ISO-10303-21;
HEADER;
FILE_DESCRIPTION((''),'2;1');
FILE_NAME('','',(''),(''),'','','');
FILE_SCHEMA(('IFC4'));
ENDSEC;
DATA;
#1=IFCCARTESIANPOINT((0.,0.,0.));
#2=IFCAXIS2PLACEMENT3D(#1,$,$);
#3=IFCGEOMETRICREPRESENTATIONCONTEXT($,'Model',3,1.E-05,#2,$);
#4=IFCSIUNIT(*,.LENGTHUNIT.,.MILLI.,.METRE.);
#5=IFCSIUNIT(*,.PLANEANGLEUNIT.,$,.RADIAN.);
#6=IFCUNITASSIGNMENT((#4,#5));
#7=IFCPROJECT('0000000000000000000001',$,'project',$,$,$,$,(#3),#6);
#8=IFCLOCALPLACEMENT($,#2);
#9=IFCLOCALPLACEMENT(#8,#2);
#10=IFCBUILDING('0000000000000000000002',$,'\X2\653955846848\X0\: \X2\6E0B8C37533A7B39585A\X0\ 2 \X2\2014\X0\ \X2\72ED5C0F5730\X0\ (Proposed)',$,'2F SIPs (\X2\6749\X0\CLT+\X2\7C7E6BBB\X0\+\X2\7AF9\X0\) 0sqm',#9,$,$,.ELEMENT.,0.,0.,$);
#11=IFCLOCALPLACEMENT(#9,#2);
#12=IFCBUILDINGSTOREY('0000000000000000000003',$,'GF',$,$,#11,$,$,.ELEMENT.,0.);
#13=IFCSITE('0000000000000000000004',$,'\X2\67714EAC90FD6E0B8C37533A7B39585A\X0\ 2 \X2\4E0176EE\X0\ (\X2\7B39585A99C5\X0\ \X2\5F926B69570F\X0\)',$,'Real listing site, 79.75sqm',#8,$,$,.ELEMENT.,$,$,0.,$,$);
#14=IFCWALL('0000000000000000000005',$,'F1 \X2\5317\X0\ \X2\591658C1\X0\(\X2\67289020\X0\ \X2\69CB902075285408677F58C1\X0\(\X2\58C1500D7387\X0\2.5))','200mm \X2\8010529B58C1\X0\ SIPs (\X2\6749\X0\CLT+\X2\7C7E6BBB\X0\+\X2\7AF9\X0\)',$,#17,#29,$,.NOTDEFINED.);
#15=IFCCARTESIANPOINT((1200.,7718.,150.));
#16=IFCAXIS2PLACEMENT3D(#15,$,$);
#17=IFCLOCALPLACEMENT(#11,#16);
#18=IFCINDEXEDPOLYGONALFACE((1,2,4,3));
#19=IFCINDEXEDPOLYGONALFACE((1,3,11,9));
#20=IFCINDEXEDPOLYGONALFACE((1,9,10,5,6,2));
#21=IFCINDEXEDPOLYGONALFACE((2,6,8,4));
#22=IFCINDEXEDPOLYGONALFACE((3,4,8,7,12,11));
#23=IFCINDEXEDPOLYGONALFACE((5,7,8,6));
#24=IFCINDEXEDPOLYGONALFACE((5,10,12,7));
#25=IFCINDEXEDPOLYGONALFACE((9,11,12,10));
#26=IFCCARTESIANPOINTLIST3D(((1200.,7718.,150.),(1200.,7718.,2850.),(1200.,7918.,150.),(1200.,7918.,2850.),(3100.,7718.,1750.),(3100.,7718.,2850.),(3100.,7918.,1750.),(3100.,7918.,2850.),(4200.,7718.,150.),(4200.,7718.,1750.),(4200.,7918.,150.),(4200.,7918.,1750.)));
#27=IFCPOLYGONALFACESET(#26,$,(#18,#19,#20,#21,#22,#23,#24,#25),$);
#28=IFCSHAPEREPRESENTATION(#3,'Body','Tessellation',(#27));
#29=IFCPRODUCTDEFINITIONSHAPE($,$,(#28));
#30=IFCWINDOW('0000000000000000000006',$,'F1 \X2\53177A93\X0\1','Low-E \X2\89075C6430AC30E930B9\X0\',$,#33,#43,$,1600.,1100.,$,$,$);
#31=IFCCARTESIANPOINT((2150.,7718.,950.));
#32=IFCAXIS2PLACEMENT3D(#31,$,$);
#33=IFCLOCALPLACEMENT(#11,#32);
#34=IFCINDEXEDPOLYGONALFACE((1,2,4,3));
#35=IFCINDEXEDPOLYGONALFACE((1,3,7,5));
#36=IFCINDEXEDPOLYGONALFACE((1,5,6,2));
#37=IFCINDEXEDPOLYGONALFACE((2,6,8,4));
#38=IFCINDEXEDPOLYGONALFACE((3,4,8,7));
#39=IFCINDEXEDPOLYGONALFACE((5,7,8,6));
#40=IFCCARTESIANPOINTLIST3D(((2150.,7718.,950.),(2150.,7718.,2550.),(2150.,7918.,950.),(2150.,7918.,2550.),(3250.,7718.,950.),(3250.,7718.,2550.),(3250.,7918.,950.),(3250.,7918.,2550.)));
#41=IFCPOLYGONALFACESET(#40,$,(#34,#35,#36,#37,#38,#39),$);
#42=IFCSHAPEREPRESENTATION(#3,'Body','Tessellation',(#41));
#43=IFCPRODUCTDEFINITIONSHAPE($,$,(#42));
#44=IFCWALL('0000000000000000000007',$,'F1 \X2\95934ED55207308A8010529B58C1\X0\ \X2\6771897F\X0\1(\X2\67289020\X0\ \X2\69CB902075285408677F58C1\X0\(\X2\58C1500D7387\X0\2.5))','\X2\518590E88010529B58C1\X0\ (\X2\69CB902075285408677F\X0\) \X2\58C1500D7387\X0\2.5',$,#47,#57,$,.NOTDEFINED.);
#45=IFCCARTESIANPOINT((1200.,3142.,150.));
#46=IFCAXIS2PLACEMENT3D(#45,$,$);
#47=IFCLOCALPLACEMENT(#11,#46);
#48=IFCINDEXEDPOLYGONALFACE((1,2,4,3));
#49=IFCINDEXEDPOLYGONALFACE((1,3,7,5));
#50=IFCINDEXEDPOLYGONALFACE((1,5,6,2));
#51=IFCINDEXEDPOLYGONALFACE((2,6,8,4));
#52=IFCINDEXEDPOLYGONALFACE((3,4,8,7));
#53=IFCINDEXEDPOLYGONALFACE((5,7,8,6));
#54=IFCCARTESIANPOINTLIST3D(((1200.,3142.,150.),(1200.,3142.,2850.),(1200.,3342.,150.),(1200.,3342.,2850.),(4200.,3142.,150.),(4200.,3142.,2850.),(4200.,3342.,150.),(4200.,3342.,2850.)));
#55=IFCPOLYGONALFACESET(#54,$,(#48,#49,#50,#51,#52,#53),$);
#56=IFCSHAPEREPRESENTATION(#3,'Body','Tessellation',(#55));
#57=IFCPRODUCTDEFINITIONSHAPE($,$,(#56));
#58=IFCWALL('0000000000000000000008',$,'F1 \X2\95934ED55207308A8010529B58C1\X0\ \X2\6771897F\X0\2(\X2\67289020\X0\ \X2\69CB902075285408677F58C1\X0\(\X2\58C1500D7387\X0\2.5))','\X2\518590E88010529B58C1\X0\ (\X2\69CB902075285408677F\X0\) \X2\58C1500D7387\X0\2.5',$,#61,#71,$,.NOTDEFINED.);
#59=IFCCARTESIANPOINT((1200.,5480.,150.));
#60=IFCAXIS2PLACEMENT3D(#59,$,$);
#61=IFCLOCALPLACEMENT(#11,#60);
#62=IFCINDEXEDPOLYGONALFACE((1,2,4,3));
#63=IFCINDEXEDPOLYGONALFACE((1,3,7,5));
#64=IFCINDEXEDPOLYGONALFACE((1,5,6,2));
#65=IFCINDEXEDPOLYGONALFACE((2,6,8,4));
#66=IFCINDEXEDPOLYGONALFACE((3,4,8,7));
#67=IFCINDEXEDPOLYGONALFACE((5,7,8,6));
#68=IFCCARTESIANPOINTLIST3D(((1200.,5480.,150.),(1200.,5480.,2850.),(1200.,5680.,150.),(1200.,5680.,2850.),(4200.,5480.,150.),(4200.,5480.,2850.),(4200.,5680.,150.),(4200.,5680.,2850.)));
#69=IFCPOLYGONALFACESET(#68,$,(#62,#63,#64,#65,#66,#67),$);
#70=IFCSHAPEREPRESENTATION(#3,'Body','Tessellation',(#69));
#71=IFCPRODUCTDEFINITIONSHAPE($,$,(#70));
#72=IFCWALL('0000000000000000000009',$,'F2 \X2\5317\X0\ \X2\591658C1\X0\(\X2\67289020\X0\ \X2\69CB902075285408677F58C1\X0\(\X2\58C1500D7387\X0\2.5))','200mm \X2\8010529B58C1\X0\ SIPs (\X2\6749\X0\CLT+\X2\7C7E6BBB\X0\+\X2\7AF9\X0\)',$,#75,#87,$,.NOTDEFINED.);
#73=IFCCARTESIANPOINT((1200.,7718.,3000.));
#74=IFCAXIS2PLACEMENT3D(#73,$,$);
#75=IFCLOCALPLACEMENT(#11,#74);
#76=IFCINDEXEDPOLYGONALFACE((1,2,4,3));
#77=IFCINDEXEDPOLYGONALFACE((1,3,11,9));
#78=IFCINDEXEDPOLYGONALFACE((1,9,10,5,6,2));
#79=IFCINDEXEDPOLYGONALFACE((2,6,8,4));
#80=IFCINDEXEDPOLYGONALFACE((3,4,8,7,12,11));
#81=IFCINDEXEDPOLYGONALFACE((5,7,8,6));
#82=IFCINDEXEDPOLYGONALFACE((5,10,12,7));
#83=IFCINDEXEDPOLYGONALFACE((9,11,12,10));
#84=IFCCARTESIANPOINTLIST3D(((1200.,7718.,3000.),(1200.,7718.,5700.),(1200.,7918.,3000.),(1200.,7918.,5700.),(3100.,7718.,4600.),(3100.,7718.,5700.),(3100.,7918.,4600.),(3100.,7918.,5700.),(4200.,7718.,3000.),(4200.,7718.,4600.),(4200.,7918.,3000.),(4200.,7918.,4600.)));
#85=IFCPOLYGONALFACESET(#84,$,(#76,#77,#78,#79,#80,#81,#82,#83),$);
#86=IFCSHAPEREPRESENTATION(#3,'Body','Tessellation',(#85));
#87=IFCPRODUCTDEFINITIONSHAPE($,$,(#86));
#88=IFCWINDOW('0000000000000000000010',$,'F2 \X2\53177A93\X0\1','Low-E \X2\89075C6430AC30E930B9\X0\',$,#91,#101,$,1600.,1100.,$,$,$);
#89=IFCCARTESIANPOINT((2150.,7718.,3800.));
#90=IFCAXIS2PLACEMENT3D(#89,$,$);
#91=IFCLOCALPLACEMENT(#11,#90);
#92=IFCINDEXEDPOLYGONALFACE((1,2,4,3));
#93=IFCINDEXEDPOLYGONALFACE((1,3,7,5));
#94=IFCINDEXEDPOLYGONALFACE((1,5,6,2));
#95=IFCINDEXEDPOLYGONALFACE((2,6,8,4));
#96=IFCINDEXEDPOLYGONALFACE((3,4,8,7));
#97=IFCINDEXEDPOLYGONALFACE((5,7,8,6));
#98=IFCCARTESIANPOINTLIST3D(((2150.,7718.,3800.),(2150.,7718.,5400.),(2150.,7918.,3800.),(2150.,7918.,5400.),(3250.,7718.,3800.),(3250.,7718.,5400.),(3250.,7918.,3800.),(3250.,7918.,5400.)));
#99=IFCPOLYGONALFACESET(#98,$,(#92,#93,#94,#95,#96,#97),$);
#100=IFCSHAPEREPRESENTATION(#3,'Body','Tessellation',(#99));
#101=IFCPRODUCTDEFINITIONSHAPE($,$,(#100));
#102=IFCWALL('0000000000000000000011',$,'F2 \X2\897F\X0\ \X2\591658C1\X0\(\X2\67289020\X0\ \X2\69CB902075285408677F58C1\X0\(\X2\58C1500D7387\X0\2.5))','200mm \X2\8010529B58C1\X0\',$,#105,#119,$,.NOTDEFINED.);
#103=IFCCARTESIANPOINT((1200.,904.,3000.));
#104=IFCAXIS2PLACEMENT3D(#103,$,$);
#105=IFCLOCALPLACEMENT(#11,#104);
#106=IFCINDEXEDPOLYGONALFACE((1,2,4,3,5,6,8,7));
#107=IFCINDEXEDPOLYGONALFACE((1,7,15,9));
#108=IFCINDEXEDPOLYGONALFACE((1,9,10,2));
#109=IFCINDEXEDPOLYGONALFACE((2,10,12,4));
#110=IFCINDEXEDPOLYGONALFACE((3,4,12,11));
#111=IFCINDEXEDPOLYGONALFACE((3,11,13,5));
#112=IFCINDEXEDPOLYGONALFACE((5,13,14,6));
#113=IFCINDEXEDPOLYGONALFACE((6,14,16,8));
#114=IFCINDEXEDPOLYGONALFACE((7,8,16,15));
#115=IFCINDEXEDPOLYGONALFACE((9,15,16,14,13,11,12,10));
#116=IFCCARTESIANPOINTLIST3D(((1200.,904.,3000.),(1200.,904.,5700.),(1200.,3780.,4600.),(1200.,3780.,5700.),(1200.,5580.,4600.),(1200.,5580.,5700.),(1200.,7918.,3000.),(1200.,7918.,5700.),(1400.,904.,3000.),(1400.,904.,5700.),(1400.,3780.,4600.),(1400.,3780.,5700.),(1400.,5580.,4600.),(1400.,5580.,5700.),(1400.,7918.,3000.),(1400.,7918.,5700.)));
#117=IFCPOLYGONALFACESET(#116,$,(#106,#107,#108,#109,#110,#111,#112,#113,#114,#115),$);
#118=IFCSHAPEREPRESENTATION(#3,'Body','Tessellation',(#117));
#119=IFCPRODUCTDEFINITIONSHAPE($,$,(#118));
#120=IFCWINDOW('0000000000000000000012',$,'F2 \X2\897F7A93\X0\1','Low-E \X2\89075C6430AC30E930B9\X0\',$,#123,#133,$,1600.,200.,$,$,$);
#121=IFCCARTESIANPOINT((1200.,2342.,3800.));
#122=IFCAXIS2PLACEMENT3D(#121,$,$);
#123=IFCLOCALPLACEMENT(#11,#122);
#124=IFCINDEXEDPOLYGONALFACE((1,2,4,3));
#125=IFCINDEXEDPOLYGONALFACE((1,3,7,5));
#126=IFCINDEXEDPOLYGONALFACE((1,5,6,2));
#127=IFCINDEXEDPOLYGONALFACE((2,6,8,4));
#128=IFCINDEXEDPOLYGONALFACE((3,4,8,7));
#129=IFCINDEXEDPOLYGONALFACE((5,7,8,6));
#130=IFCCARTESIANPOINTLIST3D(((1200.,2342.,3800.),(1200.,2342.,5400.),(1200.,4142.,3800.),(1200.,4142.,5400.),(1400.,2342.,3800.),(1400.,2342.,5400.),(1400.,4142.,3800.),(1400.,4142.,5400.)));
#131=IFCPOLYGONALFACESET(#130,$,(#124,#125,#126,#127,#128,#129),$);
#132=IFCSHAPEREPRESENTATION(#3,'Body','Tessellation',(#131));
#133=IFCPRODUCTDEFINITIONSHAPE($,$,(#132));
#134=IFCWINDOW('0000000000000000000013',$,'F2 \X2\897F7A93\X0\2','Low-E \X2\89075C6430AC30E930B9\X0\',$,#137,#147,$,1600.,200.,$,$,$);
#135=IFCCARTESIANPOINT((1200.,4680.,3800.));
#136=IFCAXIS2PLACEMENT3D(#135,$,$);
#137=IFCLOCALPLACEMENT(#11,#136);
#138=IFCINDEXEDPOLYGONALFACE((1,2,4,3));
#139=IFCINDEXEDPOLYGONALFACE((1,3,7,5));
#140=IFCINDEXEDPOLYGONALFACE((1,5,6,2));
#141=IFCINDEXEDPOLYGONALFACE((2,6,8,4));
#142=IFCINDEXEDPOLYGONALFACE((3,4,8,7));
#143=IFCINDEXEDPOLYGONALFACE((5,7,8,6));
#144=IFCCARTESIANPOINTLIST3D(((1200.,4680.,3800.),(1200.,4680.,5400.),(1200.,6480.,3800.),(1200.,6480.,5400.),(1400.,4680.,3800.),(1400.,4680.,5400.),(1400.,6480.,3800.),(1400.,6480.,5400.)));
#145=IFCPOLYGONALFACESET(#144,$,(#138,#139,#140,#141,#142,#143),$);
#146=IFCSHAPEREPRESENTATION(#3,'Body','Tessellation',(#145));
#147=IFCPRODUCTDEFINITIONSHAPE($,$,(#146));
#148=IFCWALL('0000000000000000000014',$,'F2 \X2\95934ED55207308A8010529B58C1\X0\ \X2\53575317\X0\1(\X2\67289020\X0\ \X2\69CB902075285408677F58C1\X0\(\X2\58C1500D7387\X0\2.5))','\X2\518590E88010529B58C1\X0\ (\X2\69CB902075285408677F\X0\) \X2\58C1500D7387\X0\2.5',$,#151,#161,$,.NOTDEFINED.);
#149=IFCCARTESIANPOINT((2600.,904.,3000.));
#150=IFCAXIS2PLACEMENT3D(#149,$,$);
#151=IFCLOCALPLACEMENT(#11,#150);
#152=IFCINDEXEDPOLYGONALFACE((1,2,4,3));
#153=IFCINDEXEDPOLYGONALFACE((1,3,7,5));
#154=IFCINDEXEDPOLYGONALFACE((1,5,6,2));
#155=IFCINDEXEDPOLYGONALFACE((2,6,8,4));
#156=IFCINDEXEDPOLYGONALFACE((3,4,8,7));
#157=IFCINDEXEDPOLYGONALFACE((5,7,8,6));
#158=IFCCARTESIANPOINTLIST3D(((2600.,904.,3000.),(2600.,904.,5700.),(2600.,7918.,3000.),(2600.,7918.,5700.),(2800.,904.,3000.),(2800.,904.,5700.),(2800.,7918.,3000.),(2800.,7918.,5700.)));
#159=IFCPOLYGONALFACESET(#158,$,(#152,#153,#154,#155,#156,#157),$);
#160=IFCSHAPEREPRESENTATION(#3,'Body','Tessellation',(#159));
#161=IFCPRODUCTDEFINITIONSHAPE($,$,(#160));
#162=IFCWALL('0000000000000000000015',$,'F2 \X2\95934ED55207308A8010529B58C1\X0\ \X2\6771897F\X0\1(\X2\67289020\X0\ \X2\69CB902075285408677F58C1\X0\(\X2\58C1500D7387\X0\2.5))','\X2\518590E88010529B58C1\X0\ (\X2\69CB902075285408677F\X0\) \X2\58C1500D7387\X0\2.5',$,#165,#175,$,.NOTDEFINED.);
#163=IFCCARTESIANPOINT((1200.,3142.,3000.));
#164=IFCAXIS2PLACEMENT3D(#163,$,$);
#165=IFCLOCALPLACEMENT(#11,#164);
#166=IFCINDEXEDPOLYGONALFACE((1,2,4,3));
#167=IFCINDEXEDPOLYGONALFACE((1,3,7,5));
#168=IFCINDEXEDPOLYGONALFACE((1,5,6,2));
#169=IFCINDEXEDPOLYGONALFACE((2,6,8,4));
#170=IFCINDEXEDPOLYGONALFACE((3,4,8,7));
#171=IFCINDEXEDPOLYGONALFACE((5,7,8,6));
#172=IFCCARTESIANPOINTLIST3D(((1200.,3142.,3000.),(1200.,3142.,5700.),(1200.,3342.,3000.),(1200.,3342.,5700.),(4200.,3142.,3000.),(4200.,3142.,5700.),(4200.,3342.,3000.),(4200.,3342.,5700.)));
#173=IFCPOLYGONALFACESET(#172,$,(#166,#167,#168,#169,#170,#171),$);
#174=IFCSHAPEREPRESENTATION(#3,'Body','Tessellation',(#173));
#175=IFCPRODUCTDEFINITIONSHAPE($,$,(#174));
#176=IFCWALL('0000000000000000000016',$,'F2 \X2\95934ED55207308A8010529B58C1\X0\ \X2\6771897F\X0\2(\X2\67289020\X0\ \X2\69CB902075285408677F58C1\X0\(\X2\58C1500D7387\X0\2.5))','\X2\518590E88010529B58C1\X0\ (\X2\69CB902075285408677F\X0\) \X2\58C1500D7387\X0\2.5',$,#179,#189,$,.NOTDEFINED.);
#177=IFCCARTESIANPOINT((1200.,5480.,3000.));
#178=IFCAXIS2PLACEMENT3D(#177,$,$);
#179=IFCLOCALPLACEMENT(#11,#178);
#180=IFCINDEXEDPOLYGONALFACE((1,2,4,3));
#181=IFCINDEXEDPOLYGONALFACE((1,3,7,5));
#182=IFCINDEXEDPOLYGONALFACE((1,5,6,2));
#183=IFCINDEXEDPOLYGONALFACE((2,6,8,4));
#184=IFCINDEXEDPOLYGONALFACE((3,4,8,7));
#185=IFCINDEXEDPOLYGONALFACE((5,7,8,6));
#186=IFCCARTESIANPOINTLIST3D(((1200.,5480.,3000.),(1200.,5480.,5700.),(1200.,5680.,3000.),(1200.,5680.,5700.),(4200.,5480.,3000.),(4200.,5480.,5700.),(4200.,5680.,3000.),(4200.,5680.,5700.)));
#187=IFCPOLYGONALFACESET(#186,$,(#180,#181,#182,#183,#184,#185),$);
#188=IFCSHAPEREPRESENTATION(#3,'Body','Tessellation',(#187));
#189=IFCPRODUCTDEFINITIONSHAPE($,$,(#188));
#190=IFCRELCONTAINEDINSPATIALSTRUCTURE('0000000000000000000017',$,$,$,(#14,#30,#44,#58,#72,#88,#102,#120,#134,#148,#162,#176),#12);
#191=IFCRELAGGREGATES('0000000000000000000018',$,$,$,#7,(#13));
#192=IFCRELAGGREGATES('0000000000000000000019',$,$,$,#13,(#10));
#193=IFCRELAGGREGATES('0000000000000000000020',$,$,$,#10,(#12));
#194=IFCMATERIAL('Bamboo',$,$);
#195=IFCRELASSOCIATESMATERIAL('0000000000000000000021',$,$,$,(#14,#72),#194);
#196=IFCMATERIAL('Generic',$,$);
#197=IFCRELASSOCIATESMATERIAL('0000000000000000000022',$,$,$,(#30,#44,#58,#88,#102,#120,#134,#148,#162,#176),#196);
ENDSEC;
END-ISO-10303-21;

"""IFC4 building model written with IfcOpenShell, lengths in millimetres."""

from ifc_helpers import new_model, si_unit, frame, frame_2d, origin, place, context, project, spatial, rectangle, extrude, material, element, fill, save


model = new_model("IFC4")

# Units and contexts
model_context = context("Model", 3, precision=1e-05, world=origin())
ifc_project = project(units=[si_unit("LENGTHUNIT", "METRE", prefix="MILLI"), si_unit("PLANEANGLEUNIT", "RADIAN")], contexts=[model_context])

# Site, building, storey
site_placement = place(None, origin())
site = spatial("IfcSite", under=ifc_project, at=site_placement, Name="東京都渋谷区笹塚 2 丁目 (笹塚駅 徒歩圏)", ObjectType="Real listing site, 79.75sqm", CompositionType="ELEMENT", RefElevation=0.0)
building_placement = place(site_placement, origin())
building = spatial("IfcBuilding", under=site, at=building_placement, Name="改善案: 渋谷区笹塚 2 — 狭小地 (Proposed)", ObjectType="2F SIPs (杉CLT+籾殻+竹) 0sqm", CompositionType="ELEMENT", ElevationOfRefHeight=0.0, ElevationOfTerrain=0.0)
storey_placement = place(building_placement, origin())
storey = spatial("IfcBuildingStorey", under=building, at=storey_placement, Name="GF", CompositionType="ELEMENT", Elevation=0.0)

# Wall, opening, window
ifc_material_1 = material(Name="Bamboo")
wall_1_placement = place(storey_placement, frame((1200.0, 7718.0, 150.0)))
wall_1 = element("IfcWall", 1, at=wall_1_placement, inside=storey, material=ifc_material_1, Name="F1 北 外壁(木造 構造用合板壁(壁倍率2.5))", Description="200mm 耐力壁 SIPs (杉CLT+籾殻+竹)", PredefinedType="NOTDEFINED", context=model_context, shape_type="SweptSolid", body=[
    extrude(rectangle(XDim=3000.0, YDim=200.0, at=frame_2d((1500.0, 100.0))), frame((1200.0, 7718.0, 150.0)), (0.0, 0.0, 1.0), 2700.0),
])
opening_1_placement = place(storey_placement, frame((2150.0, 7718.0, 950.0)))
opening_1 = element("IfcOpeningElement", 2, at=opening_1_placement, cuts=wall_1, PredefinedType="NOTDEFINED", context=model_context, shape_type="SweptSolid", body=[
    extrude(rectangle(XDim=1100.0, YDim=200.0, at=frame_2d((550.0, 100.0))), frame((2150.0, 7718.0, 950.0)), (0.0, 0.0, 1.0), 1600.0),
])
ifc_material_2 = material(Name="Generic")
window_1_placement = place(storey_placement, frame((2150.0, 7718.0, 950.0)))
window_1 = element("IfcWindow", 3, at=window_1_placement, inside=storey, material=ifc_material_2, Name="F1 北窓1", Description="Low-E 複層ガラス", OverallHeight=1600.0, OverallWidth=1100.0, context=model_context, shape_type="SweptSolid", body=[
    extrude(rectangle(XDim=1100.0, YDim=200.0, at=frame_2d((550.0, 100.0))), frame((2150.0, 7718.0, 950.0)), (0.0, 0.0, 1.0), 1600.0),
])
fill(opening_1, window_1)

# Walls
wall_2_placement = place(storey_placement, frame((1200.0, 3142.0, 150.0)))
element("IfcWall", 4, at=wall_2_placement, inside=storey, material=ifc_material_2, Name="F1 間仕切り耐力壁 東西1(木造 構造用合板壁(壁倍率2.5))", Description="内部耐力壁 (構造用合板) 壁倍率2.5", PredefinedType="NOTDEFINED", context=model_context, shape_type="SweptSolid", body=[
    extrude(rectangle(XDim=3000.0, YDim=200.0, at=frame_2d((1500.0, 100.0))), frame((1200.0, 3142.0, 150.0)), (0.0, 0.0, 1.0), 2700.0),
])
wall_3_placement = place(storey_placement, frame((1200.0, 5480.0, 150.0)))
element("IfcWall", 5, at=wall_3_placement, inside=storey, material=ifc_material_2, Name="F1 間仕切り耐力壁 東西2(木造 構造用合板壁(壁倍率2.5))", Description="内部耐力壁 (構造用合板) 壁倍率2.5", PredefinedType="NOTDEFINED", context=model_context, shape_type="SweptSolid", body=[
    extrude(rectangle(XDim=3000.0, YDim=200.0, at=frame_2d((1500.0, 100.0))), frame((1200.0, 5480.0, 150.0)), (0.0, 0.0, 1.0), 2700.0),
])

# Wall, opening, window
wall_4_placement = place(storey_placement, frame((1200.0, 7718.0, 3000.0)))
wall_4 = element("IfcWall", 6, at=wall_4_placement, inside=storey, material=ifc_material_1, Name="F2 北 外壁(木造 構造用合板壁(壁倍率2.5))", Description="200mm 耐力壁 SIPs (杉CLT+籾殻+竹)", PredefinedType="NOTDEFINED", context=model_context, shape_type="SweptSolid", body=[
    extrude(rectangle(XDim=3000.0, YDim=200.0, at=frame_2d((1500.0, 100.0))), frame((1200.0, 7718.0, 3000.0)), (0.0, 0.0, 1.0), 2700.0),
])
opening_2_placement = place(storey_placement, frame((2150.0, 7718.0, 3800.0)))
opening_2 = element("IfcOpeningElement", 7, at=opening_2_placement, cuts=wall_4, PredefinedType="NOTDEFINED", context=model_context, shape_type="SweptSolid", body=[
    extrude(rectangle(XDim=1100.0, YDim=200.0, at=frame_2d((550.0, 100.0))), frame((2150.0, 7718.0, 3800.0)), (0.0, 0.0, 1.0), 1600.0),
])
window_2_placement = place(storey_placement, frame((2150.0, 7718.0, 3800.0)))
window_2 = element("IfcWindow", 8, at=window_2_placement, inside=storey, material=ifc_material_2, Name="F2 北窓1", Description="Low-E 複層ガラス", OverallHeight=1600.0, OverallWidth=1100.0, context=model_context, shape_type="SweptSolid", body=[
    extrude(rectangle(XDim=1100.0, YDim=200.0, at=frame_2d((550.0, 100.0))), frame((2150.0, 7718.0, 3800.0)), (0.0, 0.0, 1.0), 1600.0),
])
fill(opening_2, window_2)

# Wall, openings, windows
wall_5_placement = place(storey_placement, frame((1200.0, 904.0, 3000.0)))
wall_5 = element("IfcWall", 9, at=wall_5_placement, inside=storey, material=ifc_material_2, Name="F2 西 外壁(木造 構造用合板壁(壁倍率2.5))", Description="200mm 耐力壁", PredefinedType="NOTDEFINED", context=model_context, shape_type="SweptSolid", body=[
    extrude(rectangle(XDim=200.0, YDim=7014.0, at=frame_2d((100.0, 3507.0))), frame((1200.0, 904.0, 3000.0)), (0.0, 0.0, 1.0), 2700.0),
])
opening_3_placement = place(storey_placement, frame((1200.0, 2342.0, 3800.0)))
opening_3 = element("IfcOpeningElement", 10, at=opening_3_placement, cuts=wall_5, PredefinedType="NOTDEFINED", context=model_context, shape_type="SweptSolid", body=[
    extrude(rectangle(XDim=200.0, YDim=1800.0, at=frame_2d((100.0, 900.0))), frame((1200.0, 2342.0, 3800.0)), (0.0, 0.0, 1.0), 1600.0),
])
opening_4_placement = place(storey_placement, frame((1200.0, 4680.0, 3800.0)))
opening_4 = element("IfcOpeningElement", 11, at=opening_4_placement, cuts=wall_5, PredefinedType="NOTDEFINED", context=model_context, shape_type="SweptSolid", body=[
    extrude(rectangle(XDim=200.0, YDim=1800.0, at=frame_2d((100.0, 900.0))), frame((1200.0, 4680.0, 3800.0)), (0.0, 0.0, 1.0), 1600.0),
])
window_3_placement = place(storey_placement, frame((1200.0, 2342.0, 3800.0)))
window_3 = element("IfcWindow", 12, at=window_3_placement, inside=storey, material=ifc_material_2, Name="F2 西窓1", Description="Low-E 複層ガラス", OverallHeight=1600.0, OverallWidth=200.0, context=model_context, shape_type="SweptSolid", body=[
    extrude(rectangle(XDim=200.0, YDim=1800.0, at=frame_2d((100.0, 900.0))), frame((1200.0, 2342.0, 3800.0)), (0.0, 0.0, 1.0), 1600.0),
])
fill(opening_3, window_3)
window_4_placement = place(storey_placement, frame((1200.0, 4680.0, 3800.0)))
window_4 = element("IfcWindow", 13, at=window_4_placement, inside=storey, material=ifc_material_2, Name="F2 西窓2", Description="Low-E 複層ガラス", OverallHeight=1600.0, OverallWidth=200.0, context=model_context, shape_type="SweptSolid", body=[
    extrude(rectangle(XDim=200.0, YDim=1800.0, at=frame_2d((100.0, 900.0))), frame((1200.0, 4680.0, 3800.0)), (0.0, 0.0, 1.0), 1600.0),
])
fill(opening_4, window_4)

# Walls
wall_6_placement = place(storey_placement, frame((2600.0, 904.0, 3000.0)))
element("IfcWall", 14, at=wall_6_placement, inside=storey, material=ifc_material_2, Name="F2 間仕切り耐力壁 南北1(木造 構造用合板壁(壁倍率2.5))", Description="内部耐力壁 (構造用合板) 壁倍率2.5", PredefinedType="NOTDEFINED", context=model_context, shape_type="SweptSolid", body=[
    extrude(rectangle(XDim=200.0, YDim=7014.0, at=frame_2d((100.0, 3507.0))), frame((2600.0, 904.0, 3000.0)), (0.0, 0.0, 1.0), 2700.0),
])
wall_7_placement = place(storey_placement, frame((1200.0, 3142.0, 3000.0)))
element("IfcWall", 15, at=wall_7_placement, inside=storey, material=ifc_material_2, Name="F2 間仕切り耐力壁 東西1(木造 構造用合板壁(壁倍率2.5))", Description="内部耐力壁 (構造用合板) 壁倍率2.5", PredefinedType="NOTDEFINED", context=model_context, shape_type="SweptSolid", body=[
    extrude(rectangle(XDim=3000.0, YDim=200.0, at=frame_2d((1500.0, 100.0))), frame((1200.0, 3142.0, 3000.0)), (0.0, 0.0, 1.0), 2700.0),
])
wall_8_placement = place(storey_placement, frame((1200.0, 5480.0, 3000.0)))
element("IfcWall", 16, at=wall_8_placement, inside=storey, material=ifc_material_2, Name="F2 間仕切り耐力壁 東西2(木造 構造用合板壁(壁倍率2.5))", Description="内部耐力壁 (構造用合板) 壁倍率2.5", PredefinedType="NOTDEFINED", context=model_context, shape_type="SweptSolid", body=[
    extrude(rectangle(XDim=3000.0, YDim=200.0, at=frame_2d((1500.0, 100.0))), frame((1200.0, 5480.0, 3000.0)), (0.0, 0.0, 1.0), 2700.0),
])

save(model, "model.ifc")
